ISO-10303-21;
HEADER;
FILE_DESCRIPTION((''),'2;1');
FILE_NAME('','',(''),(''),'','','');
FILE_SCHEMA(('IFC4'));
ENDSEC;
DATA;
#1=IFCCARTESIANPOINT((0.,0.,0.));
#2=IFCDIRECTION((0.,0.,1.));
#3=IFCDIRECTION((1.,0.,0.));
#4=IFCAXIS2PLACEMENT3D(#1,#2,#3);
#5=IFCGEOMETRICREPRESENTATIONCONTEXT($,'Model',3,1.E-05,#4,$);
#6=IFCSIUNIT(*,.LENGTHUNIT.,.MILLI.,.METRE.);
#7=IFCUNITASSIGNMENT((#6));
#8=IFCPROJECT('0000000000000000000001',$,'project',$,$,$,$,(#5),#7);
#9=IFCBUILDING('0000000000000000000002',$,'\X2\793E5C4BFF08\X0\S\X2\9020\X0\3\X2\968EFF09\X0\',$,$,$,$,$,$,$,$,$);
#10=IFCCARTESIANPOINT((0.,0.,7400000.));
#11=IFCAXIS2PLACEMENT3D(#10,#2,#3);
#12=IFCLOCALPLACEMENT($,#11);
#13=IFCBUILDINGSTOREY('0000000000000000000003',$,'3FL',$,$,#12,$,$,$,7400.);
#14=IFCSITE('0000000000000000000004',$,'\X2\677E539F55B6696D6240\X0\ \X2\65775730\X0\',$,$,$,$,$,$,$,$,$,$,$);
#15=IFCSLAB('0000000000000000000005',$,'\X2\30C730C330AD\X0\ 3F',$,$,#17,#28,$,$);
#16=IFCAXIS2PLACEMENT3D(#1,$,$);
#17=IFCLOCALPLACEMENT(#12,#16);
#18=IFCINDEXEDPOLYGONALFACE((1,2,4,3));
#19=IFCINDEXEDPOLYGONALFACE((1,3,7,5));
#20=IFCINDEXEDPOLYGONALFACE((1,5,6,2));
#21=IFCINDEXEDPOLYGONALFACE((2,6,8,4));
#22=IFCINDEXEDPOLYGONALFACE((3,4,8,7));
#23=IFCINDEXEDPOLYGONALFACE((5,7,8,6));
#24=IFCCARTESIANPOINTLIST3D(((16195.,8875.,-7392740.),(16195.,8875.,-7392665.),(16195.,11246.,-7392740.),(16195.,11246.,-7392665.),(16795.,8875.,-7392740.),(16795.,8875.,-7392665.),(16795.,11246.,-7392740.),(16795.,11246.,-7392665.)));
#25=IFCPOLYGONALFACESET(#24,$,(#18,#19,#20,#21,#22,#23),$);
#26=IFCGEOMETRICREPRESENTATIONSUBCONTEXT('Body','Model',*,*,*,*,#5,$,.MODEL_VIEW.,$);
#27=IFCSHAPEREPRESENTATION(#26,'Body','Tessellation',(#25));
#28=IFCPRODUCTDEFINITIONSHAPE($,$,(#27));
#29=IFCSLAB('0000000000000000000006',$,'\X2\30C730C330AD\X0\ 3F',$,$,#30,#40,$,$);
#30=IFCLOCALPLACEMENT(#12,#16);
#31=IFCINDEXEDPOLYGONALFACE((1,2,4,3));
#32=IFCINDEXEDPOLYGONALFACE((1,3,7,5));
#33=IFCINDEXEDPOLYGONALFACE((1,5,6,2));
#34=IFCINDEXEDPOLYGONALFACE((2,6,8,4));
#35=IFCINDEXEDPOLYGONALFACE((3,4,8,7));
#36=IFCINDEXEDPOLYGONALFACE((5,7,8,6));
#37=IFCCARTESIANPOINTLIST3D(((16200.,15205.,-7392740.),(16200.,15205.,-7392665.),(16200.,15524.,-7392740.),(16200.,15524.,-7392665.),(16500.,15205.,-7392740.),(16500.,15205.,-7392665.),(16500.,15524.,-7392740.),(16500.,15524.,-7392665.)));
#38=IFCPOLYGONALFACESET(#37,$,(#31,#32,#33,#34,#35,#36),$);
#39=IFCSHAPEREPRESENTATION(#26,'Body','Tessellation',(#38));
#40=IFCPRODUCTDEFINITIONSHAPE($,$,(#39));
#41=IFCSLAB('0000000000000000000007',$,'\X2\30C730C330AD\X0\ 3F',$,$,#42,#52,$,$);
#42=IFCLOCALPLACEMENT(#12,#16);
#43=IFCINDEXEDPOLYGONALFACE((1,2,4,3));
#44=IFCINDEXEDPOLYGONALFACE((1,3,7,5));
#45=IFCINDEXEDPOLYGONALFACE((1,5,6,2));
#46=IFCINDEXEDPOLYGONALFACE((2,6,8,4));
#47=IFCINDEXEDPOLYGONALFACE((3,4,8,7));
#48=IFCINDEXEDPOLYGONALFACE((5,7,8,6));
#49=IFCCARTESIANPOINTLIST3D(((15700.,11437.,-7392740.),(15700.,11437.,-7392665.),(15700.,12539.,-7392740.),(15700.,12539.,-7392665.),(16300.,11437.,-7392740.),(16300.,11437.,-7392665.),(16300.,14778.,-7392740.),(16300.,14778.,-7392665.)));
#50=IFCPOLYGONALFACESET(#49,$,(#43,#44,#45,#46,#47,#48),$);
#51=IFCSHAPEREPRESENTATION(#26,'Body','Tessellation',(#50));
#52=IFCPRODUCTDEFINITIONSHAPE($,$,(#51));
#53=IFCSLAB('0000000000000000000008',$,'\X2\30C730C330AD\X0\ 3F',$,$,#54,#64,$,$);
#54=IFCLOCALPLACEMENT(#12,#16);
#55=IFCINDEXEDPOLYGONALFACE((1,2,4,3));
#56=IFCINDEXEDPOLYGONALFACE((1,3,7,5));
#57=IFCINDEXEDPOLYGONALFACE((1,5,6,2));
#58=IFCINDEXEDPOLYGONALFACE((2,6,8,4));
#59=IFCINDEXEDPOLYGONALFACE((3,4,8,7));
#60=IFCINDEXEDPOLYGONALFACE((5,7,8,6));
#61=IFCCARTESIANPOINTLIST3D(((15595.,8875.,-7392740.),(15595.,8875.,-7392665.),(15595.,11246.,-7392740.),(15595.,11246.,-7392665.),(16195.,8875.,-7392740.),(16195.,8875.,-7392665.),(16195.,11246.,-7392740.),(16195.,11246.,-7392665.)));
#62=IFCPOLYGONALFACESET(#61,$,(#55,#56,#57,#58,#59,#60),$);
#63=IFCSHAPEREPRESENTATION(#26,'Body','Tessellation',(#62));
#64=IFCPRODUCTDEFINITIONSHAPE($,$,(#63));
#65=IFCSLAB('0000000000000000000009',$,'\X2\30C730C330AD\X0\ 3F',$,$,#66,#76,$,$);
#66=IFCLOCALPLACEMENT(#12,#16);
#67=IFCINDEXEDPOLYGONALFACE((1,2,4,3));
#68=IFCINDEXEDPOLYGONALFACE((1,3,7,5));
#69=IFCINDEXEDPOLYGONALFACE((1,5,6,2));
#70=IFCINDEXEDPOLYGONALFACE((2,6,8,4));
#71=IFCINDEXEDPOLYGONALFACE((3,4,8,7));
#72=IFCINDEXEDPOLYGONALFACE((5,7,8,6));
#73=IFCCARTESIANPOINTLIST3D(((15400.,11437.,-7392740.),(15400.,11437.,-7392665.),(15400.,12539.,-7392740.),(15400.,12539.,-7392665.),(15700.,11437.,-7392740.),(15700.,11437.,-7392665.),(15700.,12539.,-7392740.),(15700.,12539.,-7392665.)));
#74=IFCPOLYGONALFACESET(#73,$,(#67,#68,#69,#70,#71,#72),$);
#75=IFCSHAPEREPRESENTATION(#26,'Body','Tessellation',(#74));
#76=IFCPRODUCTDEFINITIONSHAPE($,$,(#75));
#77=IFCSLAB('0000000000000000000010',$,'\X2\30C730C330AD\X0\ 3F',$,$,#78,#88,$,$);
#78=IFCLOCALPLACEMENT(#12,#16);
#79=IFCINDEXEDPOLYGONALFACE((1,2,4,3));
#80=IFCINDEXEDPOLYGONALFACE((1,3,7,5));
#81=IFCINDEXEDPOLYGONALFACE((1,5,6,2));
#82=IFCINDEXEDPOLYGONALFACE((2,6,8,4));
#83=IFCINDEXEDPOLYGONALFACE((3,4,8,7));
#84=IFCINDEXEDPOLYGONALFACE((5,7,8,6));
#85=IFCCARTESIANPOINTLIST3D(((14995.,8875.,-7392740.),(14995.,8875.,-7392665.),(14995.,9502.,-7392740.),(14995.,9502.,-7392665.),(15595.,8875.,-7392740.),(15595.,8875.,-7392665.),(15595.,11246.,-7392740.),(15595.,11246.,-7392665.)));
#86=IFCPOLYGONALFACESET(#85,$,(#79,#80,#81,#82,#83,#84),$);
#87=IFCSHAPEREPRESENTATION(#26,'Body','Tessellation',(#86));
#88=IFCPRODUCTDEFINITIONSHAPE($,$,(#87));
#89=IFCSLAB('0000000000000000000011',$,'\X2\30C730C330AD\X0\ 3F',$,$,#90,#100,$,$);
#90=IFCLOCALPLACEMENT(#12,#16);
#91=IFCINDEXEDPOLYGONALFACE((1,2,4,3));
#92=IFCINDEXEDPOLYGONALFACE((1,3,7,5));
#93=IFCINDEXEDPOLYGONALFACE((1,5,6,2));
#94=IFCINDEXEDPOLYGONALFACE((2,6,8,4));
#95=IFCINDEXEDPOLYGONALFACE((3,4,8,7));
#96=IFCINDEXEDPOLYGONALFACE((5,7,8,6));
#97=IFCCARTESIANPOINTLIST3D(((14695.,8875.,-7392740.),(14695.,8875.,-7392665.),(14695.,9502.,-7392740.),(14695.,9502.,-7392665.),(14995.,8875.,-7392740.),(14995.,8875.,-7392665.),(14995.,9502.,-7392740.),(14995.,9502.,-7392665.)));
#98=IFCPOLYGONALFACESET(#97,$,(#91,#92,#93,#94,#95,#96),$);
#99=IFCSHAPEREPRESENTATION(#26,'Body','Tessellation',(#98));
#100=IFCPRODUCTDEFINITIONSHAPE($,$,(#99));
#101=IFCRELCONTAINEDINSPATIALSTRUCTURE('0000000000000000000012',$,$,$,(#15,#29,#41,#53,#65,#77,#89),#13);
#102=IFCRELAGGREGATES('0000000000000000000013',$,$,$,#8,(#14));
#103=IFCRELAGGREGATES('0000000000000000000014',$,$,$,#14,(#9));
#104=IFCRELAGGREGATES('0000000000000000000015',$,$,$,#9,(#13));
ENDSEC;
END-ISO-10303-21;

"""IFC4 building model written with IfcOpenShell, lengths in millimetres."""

from ifc_helpers import new_model, si_unit, frame, origin, origin_with_axes, place, context, subcontext, project, spatial, polyline, outline, extrude, element, save


model = new_model("IFC4")

# Units and contexts
model_context = context("Model", 3, precision=1e-05, world=origin_with_axes())
body_context = subcontext(model_context, "Body", "Model", "MODEL_VIEW")
ifc_project = project(units=[si_unit("LENGTHUNIT", "METRE", prefix="MILLI")], contexts=[model_context])

# Site, building, storey
site = spatial("IfcSite", under=ifc_project, Name="松原営業所 敷地")
building = spatial("IfcBuilding", under=site, Name="社屋（S造3階）")
storey_placement = place(None, frame((0.0, 0.0, 7400000.0), z_axis=(0.0, 0.0, 1.0), x_axis=(1.0, 0.0, 0.0)))
storey = spatial("IfcBuildingStorey", under=building, at=storey_placement, Name="3FL", Elevation=7400.0)

# Slabs
slab_1_placement = place(storey_placement, frame((0.0, 0.0, -7392740.0), z_axis=(0.0, 0.0, 1.0), x_axis=(1.0, 0.0, 0.0)))
element("IfcSlab", 1, at=slab_1_placement, inside=storey, Name="デッキ 3F", context=body_context, shape_type="SweptSolid", body=[
    extrude(outline(polyline([(16795.0, 8875.0), (16795.0, 11246.0), (16195.0, 11246.0), (16195.0, 8875.0), (16795.0, 8875.0)])), origin(), (0.0, 0.0, 1.0), 75.0),
])
slab_2_placement = place(storey_placement, frame((0.0, 0.0, -7392740.0), z_axis=(0.0, 0.0, 1.0), x_axis=(1.0, 0.0, 0.0)))
element("IfcSlab", 2, at=slab_2_placement, inside=storey, Name="デッキ 3F", context=body_context, shape_type="SweptSolid", body=[
    extrude(outline(polyline([(16500.0, 15205.0), (16500.0, 15524.0), (16200.0, 15524.0), (16200.0, 15205.0), (16500.0, 15205.0)])), origin(), (0.0, 0.0, 1.0), 75.0),
])
slab_3_placement = place(storey_placement, frame((0.0, 0.0, -7392740.0), z_axis=(0.0, 0.0, 1.0), x_axis=(1.0, 0.0, 0.0)))
element("IfcSlab", 3, at=slab_3_placement, inside=storey, Name="デッキ 3F", context=body_context, shape_type="SweptSolid", body=[
    extrude(outline(polyline([(16300.0, 11437.0), (16300.0, 14778.0), (15700.0, 12539.0), (15700.0, 11437.0), (16300.0, 11437.0)])), origin(), (0.0, 0.0, 1.0), 75.0),
])
slab_4_placement = place(storey_placement, frame((0.0, 0.0, -7392740.0), z_axis=(0.0, 0.0, 1.0), x_axis=(1.0, 0.0, 0.0)))
element("IfcSlab", 4, at=slab_4_placement, inside=storey, Name="デッキ 3F", context=body_context, shape_type="SweptSolid", body=[
    extrude(outline(polyline([(16195.0, 8875.0), (16195.0, 11246.0), (15595.0, 11246.0), (15595.0, 8875.0), (16195.0, 8875.0)])), origin(), (0.0, 0.0, 1.0), 75.0),
])
slab_5_placement = place(storey_placement, frame((0.0, 0.0, -7392740.0), z_axis=(0.0, 0.0, 1.0), x_axis=(1.0, 0.0, 0.0)))
element("IfcSlab", 5, at=slab_5_placement, inside=storey, Name="デッキ 3F", context=body_context, shape_type="SweptSolid", body=[
    extrude(outline(polyline([(15700.0, 11437.0), (15700.0, 12539.0), (15400.0, 12539.0), (15400.0, 11437.0), (15700.0, 11437.0)])), origin(), (0.0, 0.0, 1.0), 75.0),
])
slab_6_placement = place(storey_placement, frame((0.0, 0.0, -7392740.0), z_axis=(0.0, 0.0, 1.0), x_axis=(1.0, 0.0, 0.0)))
element("IfcSlab", 6, at=slab_6_placement, inside=storey, Name="デッキ 3F", context=body_context, shape_type="SweptSolid", body=[
    extrude(outline(polyline([(15595.0, 8875.0), (15595.0, 11246.0), (14995.0, 9502.0), (14995.0, 8875.0), (15595.0, 8875.0)])), origin(), (0.0, 0.0, 1.0), 75.0),
])
slab_7_placement = place(storey_placement, frame((0.0, 0.0, -7392740.0), z_axis=(0.0, 0.0, 1.0), x_axis=(1.0, 0.0, 0.0)))
element("IfcSlab", 7, at=slab_7_placement, inside=storey, Name="デッキ 3F", context=body_context, shape_type="SweptSolid", body=[
    extrude(outline(polyline([(14995.0, 8875.0), (14995.0, 9502.0), (14695.0, 9502.0), (14695.0, 8875.0), (14995.0, 8875.0)])), origin(), (0.0, 0.0, 1.0), 75.0),
])

save(model, "model.ifc")
